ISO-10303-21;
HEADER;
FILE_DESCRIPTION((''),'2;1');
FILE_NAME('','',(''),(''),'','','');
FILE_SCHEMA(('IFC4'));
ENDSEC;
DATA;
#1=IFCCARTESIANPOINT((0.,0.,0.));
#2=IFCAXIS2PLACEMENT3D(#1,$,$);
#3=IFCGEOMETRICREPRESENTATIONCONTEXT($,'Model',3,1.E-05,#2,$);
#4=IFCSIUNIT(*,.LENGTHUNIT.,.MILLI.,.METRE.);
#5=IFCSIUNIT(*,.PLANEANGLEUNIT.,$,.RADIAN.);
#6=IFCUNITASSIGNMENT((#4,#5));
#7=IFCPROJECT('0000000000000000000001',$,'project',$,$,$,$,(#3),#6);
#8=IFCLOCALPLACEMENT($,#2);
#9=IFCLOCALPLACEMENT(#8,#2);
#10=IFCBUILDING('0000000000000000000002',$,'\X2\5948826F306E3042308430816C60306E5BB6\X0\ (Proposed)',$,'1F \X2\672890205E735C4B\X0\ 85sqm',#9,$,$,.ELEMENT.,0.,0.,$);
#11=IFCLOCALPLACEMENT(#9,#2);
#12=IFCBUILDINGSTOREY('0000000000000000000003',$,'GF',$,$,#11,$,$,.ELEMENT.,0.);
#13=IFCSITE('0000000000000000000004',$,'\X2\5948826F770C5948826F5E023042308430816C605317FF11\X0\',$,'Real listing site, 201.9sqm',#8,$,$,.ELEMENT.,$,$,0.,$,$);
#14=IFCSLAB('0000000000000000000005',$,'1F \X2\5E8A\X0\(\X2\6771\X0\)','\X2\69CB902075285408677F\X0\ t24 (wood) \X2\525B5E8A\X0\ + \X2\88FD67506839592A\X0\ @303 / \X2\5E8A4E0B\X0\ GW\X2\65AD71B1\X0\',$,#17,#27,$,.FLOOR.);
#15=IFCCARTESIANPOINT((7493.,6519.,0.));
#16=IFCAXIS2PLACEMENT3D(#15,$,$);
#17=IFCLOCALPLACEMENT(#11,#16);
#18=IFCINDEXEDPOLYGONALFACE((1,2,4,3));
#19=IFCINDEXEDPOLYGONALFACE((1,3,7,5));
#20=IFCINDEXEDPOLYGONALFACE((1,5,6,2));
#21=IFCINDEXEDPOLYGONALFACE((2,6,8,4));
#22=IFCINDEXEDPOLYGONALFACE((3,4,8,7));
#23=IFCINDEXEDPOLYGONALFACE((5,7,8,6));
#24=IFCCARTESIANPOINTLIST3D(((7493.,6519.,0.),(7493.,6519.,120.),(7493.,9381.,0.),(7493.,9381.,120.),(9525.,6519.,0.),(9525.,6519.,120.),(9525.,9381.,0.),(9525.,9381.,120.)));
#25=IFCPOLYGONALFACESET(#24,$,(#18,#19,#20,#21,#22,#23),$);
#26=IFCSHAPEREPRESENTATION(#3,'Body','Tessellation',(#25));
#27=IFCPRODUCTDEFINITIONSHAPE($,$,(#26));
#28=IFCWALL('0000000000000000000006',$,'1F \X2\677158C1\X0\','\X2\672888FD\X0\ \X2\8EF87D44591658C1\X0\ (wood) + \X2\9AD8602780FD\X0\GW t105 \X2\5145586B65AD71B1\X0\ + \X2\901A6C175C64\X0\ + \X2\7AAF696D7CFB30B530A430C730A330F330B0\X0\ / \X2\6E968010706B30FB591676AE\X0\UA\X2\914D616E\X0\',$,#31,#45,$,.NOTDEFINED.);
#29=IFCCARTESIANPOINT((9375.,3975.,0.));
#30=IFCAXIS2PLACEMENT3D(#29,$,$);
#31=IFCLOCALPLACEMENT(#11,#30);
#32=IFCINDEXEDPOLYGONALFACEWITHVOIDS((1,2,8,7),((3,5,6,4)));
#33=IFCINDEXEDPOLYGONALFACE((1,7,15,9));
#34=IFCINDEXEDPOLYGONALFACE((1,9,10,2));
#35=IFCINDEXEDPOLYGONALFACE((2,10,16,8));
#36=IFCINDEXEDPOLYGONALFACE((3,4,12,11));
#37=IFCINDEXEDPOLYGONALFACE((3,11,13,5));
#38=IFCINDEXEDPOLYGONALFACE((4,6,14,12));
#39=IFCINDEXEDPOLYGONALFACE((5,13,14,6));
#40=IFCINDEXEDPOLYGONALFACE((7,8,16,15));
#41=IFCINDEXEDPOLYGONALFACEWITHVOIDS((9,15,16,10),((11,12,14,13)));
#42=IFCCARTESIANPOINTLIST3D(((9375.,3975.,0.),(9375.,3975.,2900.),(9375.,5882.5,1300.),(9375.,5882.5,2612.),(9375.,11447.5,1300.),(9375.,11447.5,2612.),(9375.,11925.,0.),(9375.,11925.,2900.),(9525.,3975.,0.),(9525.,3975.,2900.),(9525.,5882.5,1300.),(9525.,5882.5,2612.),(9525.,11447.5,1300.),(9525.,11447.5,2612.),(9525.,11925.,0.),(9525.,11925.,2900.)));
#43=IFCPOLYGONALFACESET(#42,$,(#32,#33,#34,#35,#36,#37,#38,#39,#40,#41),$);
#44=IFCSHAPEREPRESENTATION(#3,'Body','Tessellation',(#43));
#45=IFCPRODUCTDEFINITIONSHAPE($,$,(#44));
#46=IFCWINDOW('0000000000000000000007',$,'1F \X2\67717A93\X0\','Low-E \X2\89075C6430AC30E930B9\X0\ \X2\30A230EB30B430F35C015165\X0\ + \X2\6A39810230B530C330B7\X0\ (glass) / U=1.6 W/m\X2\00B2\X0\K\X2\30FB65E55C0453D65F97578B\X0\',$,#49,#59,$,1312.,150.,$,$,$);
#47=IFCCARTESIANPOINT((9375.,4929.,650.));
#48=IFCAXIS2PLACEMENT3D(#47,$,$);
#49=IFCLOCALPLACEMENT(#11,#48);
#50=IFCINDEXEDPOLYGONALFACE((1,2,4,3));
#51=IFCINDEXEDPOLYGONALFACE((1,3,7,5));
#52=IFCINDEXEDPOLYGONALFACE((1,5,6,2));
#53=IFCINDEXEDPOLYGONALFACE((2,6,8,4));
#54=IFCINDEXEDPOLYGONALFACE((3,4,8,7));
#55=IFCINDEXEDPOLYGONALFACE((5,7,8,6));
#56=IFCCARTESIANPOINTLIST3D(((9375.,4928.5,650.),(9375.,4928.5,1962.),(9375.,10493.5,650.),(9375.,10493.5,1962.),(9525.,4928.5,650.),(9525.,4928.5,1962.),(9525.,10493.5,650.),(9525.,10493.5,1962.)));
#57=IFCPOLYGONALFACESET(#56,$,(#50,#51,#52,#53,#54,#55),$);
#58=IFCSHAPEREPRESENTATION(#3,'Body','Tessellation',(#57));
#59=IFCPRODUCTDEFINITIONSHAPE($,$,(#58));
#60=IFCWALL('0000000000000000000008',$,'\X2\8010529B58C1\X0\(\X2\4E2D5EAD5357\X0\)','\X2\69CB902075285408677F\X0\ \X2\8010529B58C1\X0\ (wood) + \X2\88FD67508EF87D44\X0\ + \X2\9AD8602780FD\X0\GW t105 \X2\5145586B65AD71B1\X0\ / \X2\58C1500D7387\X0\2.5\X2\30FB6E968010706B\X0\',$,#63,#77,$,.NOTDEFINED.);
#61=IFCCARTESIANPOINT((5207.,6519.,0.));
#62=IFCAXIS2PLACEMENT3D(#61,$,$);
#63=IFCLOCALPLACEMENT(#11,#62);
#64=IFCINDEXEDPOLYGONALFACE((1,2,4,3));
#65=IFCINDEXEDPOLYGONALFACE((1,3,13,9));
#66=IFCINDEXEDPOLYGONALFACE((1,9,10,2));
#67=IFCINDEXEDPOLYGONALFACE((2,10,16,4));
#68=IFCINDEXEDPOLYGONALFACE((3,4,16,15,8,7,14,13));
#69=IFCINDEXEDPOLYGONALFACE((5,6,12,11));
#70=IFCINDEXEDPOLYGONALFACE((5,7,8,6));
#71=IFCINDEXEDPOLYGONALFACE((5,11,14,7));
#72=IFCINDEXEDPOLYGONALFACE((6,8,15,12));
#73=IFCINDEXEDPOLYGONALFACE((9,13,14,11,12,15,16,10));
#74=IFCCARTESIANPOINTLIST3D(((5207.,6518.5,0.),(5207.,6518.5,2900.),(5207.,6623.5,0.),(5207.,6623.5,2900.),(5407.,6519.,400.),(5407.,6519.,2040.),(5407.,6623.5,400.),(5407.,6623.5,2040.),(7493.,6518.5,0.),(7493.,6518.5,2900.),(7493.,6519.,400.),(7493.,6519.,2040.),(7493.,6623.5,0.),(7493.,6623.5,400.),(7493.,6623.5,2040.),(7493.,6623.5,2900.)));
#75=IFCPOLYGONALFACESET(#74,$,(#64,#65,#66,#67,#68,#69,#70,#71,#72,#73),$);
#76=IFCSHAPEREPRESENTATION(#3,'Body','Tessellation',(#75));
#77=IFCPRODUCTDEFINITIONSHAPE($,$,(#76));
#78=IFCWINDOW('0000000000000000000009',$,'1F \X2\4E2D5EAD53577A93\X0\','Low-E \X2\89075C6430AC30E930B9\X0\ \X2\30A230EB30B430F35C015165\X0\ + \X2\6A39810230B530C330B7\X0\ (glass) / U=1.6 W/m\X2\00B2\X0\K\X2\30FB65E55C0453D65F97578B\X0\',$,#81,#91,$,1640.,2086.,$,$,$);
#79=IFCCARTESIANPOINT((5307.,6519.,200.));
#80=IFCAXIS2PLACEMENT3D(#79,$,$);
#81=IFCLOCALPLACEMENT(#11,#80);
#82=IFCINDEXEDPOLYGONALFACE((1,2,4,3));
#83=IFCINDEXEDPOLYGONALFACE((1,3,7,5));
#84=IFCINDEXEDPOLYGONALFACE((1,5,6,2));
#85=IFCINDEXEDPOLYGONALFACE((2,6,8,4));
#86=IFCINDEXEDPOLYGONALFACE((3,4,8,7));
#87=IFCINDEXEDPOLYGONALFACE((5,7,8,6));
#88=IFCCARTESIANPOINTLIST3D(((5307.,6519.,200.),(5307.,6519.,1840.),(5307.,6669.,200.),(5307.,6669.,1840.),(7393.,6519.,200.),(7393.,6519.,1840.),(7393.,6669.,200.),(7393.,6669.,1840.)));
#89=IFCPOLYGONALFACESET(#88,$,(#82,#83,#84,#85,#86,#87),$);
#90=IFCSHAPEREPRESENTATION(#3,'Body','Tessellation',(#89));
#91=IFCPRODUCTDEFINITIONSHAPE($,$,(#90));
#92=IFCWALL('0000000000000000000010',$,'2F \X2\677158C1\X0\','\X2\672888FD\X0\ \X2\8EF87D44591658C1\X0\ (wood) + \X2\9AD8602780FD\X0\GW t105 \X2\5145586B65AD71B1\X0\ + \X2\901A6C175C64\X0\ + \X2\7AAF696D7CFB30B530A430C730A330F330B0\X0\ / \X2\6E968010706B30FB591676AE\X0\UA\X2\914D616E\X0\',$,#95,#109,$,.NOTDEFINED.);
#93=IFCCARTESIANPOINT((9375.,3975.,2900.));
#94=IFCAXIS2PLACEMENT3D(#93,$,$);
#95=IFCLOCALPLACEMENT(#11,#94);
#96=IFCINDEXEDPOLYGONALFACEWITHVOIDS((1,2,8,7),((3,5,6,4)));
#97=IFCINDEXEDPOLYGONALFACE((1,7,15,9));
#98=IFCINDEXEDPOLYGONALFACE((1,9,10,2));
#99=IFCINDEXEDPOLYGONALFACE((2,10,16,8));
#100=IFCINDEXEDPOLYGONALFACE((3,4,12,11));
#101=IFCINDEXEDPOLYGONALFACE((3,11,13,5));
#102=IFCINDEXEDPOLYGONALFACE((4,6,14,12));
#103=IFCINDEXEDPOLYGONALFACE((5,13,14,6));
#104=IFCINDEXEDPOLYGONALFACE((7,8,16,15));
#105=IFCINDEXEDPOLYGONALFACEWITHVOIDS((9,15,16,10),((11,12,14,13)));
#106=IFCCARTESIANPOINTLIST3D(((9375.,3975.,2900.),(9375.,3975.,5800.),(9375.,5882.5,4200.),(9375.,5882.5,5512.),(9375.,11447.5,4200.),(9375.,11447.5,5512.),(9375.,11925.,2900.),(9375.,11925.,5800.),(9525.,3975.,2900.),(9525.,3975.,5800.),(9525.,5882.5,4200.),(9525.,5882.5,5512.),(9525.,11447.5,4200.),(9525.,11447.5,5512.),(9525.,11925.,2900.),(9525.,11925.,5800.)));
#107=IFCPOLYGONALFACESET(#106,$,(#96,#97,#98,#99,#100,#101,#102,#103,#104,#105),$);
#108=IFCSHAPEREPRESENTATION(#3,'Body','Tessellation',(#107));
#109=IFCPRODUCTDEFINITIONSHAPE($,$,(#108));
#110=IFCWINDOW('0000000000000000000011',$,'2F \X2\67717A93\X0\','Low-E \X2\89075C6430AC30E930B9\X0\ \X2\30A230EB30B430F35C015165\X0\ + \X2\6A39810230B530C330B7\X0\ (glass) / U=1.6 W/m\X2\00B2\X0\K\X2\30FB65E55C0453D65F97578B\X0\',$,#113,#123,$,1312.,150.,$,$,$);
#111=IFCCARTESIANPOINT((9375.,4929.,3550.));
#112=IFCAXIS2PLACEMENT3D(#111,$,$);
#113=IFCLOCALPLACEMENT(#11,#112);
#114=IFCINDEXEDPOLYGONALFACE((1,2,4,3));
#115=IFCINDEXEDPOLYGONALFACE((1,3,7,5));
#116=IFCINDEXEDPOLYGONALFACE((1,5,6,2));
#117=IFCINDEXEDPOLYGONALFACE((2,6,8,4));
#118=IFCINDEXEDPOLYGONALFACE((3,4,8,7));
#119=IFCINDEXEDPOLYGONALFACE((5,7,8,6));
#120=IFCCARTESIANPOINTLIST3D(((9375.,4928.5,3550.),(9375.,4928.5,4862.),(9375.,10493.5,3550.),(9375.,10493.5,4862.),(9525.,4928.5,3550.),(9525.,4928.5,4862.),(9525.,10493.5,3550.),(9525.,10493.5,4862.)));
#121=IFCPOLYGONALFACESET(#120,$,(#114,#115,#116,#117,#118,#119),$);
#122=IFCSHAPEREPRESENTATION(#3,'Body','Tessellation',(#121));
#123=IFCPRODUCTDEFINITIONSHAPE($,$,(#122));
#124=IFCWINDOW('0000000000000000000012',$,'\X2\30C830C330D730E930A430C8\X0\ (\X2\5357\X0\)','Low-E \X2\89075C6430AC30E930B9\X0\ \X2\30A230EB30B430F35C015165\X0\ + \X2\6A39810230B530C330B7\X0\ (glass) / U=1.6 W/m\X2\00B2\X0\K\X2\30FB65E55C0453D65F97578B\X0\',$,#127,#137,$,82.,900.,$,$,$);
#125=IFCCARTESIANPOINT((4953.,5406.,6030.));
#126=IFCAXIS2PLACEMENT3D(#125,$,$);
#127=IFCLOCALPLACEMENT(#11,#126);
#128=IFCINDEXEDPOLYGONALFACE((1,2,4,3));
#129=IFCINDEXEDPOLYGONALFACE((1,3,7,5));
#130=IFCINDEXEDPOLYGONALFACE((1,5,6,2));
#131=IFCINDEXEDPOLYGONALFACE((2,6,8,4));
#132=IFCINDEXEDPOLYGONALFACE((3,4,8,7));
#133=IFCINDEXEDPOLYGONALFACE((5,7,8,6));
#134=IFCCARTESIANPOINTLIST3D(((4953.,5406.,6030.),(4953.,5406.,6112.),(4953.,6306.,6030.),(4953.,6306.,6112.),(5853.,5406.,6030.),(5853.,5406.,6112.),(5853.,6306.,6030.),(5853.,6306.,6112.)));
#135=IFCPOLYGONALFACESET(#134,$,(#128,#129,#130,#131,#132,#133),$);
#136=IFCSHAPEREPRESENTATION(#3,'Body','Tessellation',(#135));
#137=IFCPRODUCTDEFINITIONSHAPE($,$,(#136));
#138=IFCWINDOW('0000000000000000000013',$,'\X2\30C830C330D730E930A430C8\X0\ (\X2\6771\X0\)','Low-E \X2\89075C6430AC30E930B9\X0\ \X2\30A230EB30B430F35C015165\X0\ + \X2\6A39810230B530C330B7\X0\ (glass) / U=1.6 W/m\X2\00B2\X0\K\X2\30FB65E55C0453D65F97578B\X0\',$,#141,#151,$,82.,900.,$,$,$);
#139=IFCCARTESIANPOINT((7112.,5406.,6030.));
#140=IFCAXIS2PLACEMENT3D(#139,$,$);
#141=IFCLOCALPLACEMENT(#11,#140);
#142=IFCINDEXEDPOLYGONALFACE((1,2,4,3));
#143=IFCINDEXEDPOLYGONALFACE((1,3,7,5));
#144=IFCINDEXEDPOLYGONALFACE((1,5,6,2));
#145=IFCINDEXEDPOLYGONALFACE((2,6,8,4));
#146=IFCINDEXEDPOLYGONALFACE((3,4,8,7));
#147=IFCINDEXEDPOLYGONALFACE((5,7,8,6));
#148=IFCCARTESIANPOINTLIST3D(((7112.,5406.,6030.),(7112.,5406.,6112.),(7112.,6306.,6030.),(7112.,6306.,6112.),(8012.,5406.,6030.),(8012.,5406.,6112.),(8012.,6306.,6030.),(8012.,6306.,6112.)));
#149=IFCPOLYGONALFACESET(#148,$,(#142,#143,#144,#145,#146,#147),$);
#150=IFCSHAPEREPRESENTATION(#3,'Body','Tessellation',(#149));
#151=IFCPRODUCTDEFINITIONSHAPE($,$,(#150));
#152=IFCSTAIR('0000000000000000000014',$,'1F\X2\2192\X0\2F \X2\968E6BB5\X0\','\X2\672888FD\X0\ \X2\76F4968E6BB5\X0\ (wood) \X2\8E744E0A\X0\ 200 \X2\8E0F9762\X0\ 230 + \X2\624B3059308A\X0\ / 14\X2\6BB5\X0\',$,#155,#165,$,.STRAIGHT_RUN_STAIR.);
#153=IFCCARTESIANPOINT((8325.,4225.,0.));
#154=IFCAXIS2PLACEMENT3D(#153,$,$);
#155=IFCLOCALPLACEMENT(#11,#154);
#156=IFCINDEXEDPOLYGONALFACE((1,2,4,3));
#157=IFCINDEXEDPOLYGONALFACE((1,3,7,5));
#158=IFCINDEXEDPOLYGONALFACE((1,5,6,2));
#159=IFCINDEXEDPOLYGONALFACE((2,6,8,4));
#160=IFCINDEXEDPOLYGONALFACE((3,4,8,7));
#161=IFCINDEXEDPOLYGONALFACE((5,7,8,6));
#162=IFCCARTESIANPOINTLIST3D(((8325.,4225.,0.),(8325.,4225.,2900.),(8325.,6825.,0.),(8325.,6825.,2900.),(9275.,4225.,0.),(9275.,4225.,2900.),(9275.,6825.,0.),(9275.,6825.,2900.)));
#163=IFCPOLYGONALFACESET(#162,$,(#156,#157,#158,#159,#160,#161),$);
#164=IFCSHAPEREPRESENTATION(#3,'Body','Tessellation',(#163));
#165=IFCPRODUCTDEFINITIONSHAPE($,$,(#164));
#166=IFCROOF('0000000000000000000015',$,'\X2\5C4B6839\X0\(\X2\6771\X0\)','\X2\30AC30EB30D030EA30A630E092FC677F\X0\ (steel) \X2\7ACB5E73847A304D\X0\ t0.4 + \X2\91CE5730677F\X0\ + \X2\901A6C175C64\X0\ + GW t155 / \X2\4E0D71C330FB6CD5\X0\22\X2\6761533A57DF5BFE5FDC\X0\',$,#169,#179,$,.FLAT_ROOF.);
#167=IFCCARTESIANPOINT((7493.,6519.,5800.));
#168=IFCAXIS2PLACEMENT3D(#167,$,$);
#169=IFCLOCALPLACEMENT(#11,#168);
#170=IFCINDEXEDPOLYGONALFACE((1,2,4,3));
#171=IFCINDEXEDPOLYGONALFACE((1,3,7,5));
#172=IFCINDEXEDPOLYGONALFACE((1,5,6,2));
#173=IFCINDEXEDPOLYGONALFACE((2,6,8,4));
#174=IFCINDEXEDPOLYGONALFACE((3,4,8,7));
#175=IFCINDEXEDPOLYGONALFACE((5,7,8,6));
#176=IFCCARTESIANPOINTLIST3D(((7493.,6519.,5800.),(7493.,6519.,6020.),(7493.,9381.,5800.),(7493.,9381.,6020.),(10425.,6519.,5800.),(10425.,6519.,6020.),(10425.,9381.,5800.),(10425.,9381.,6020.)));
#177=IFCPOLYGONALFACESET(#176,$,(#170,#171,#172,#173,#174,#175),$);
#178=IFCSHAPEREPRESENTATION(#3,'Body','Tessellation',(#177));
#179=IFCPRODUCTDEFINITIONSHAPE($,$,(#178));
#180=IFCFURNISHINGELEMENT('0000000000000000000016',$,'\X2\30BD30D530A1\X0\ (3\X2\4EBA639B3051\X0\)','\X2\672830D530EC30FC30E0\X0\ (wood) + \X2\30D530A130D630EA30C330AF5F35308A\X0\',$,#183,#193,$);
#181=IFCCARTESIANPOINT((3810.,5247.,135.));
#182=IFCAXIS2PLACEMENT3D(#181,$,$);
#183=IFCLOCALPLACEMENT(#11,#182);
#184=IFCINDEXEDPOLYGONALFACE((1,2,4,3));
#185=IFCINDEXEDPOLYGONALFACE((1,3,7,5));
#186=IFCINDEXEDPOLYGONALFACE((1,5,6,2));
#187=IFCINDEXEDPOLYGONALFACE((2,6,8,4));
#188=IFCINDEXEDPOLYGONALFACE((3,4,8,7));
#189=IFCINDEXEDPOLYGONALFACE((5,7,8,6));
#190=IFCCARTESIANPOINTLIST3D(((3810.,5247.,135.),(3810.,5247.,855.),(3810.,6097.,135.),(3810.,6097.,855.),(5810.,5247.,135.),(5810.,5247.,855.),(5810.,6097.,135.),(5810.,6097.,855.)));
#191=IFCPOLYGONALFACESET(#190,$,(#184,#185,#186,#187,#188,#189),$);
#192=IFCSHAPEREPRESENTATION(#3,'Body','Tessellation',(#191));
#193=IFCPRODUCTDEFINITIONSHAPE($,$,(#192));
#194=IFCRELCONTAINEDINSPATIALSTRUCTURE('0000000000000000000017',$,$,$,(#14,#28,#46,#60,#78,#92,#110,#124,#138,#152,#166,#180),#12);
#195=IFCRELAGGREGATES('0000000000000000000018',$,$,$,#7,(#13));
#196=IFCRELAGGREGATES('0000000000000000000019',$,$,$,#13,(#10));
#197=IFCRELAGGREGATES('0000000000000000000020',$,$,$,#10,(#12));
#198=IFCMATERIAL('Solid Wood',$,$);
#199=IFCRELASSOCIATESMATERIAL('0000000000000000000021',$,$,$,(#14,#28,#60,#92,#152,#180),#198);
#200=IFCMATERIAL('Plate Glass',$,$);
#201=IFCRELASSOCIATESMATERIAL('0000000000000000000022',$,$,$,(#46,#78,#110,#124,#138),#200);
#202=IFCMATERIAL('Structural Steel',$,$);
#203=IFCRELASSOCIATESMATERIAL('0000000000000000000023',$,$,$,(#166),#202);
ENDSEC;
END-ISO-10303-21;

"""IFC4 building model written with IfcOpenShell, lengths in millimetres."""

from ifc_helpers import new_model, si_unit, frame, frame_2d, origin, place, context, project, spatial, rectangle, extrude, material, element, fill, save


model = new_model("IFC4")

# Units and contexts
model_context = context("Model", 3, precision=1e-05, world=origin())
ifc_project = project(units=[si_unit("LENGTHUNIT", "METRE", prefix="MILLI"), si_unit("PLANEANGLEUNIT", "RADIAN")], contexts=[model_context])

# Site, building, storey
site_placement = place(None, origin())
site = spatial("IfcSite", under=ifc_project, at=site_placement, Name="奈良県奈良市あやめ池北１", ObjectType="Real listing site, 201.9sqm", CompositionType="ELEMENT", RefElevation=0.0)
building_placement = place(site_placement, origin())
building = spatial("IfcBuilding", under=site, at=building_placement, Name="奈良のあやめ池の家 (Proposed)", ObjectType="1F 木造平屋 85sqm", CompositionType="ELEMENT", ElevationOfRefHeight=0.0, ElevationOfTerrain=0.0)
storey_placement = place(building_placement, origin())
storey = spatial("IfcBuildingStorey", under=building, at=storey_placement, Name="GF", CompositionType="ELEMENT", Elevation=0.0)

# Slab
ifc_material_1 = material(Name="Solid Wood")
slab_placement = place(storey_placement, frame((7493.0, 6519.0, 0.0)))
element("IfcSlab", 1, at=slab_placement, inside=storey, material=ifc_material_1, Name="1F 床(東)", Description="構造用合板 t24 (wood) 剛床 + 製材根太 @303 / 床下 GW断熱", PredefinedType="FLOOR", context=model_context, shape_type="SweptSolid", body=[
    extrude(rectangle(XDim=2032.0, YDim=2862.0, at=frame_2d((1016.0, 1431.0))), frame((7493.0, 6519.0, 0.0)), (0.0, 0.0, 1.0), 120.0),
])

# Walls, openings, windows
wall_1_placement = place(storey_placement, frame((9375.0, 3975.0, 0.0)))
wall_1 = element("IfcWall", 2, at=wall_1_placement, inside=storey, material=ifc_material_1, Name="1F 東壁", Description="木製 軸組外壁 (wood) + 高性能GW t105 充填断熱 + 通気層 + 窯業系サイディング / 準耐火・外皮UA配慮", PredefinedType="NOTDEFINED", context=model_context, shape_type="SweptSolid", body=[
    extrude(rectangle(XDim=150.0, YDim=7950.0, at=frame_2d((75.0, 3975.0))), frame((9375.0, 3975.0, 0.0)), (0.0, 0.0, 1.0), 2900.0),
])
opening_1_placement = place(storey_placement, frame((9375.0, 4929.0, 650.0)))
opening_1 = element("IfcOpeningElement", 3, at=opening_1_placement, cuts=wall_1, PredefinedType="NOTDEFINED", context=model_context, shape_type="SweptSolid", body=[
    extrude(rectangle(XDim=150.0, YDim=5565.0, at=frame_2d((75.0, 2782.0))), frame((9375.0, 4929.0, 650.0)), (0.0, 0.0, 1.0), 1312.0),
])
ifc_material_2 = material(Name="Plate Glass")
window_1_placement = place(storey_placement, frame((9375.0, 4929.0, 650.0)))
window_1 = element("IfcWindow", 4, at=window_1_placement, inside=storey, material=ifc_material_2, Name="1F 東窓", Description="Low-E 複層ガラス アルゴン封入 + 樹脂サッシ (glass) / U=1.6 W/m²K・日射取得型", OverallHeight=1312.0, OverallWidth=150.0, context=model_context, shape_type="SweptSolid", body=[
    extrude(rectangle(XDim=150.0, YDim=5565.0, at=frame_2d((75.0, 2782.0))), frame((9375.0, 4929.0, 650.0)), (0.0, 0.0, 1.0), 1312.0),
])
fill(opening_1, window_1)
wall_2_placement = place(storey_placement, frame((5207.0, 6519.0, 0.0)))
wall_2 = element("IfcWall", 5, at=wall_2_placement, inside=storey, material=ifc_material_1, Name="耐力壁(中庭南)", Description="構造用合板 耐力壁 (wood) + 製材軸組 + 高性能GW t105 充填断熱 / 壁倍率2.5・準耐火", PredefinedType="NOTDEFINED", context=model_context, shape_type="SweptSolid", body=[
    extrude(rectangle(XDim=2286.0, YDim=105.0, at=frame_2d((1143.0, 52.0))), frame((5207.0, 6519.0, 0.0)), (0.0, 0.0, 1.0), 2900.0),
])
opening_2_placement = place(storey_placement, frame((5307.0, 6519.0, 200.0)))
opening_2 = element("IfcOpeningElement", 6, at=opening_2_placement, cuts=wall_2, PredefinedType="NOTDEFINED", context=model_context, shape_type="SweptSolid", body=[
    extrude(rectangle(XDim=2086.0, YDim=150.0, at=frame_2d((1043.0, 75.0))), frame((5307.0, 6519.0, 200.0)), (0.0, 0.0, 1.0), 1640.0),
])
window_2_placement = place(storey_placement, frame((5307.0, 6519.0, 200.0)))
window_2 = element("IfcWindow", 7, at=window_2_placement, inside=storey, material=ifc_material_2, Name="1F 中庭南窓", Description="Low-E 複層ガラス アルゴン封入 + 樹脂サッシ (glass) / U=1.6 W/m²K・日射取得型", OverallHeight=1640.0, OverallWidth=2086.0, context=model_context, shape_type="SweptSolid", body=[
    extrude(rectangle(XDim=2086.0, YDim=150.0, at=frame_2d((1043.0, 75.0))), frame((5307.0, 6519.0, 200.0)), (0.0, 0.0, 1.0), 1640.0),
])
fill(opening_2, window_2)

# Wall, opening, window
wall_3_placement = place(storey_placement, frame((9375.0, 3975.0, 2900.0)))
wall_3 = element("IfcWall", 8, at=wall_3_placement, inside=storey, material=ifc_material_1, Name="2F 東壁", Description="木製 軸組外壁 (wood) + 高性能GW t105 充填断熱 + 通気層 + 窯業系サイディング / 準耐火・外皮UA配慮", PredefinedType="NOTDEFINED", context=model_context, shape_type="SweptSolid", body=[
    extrude(rectangle(XDim=150.0, YDim=7950.0, at=frame_2d((75.0, 3975.0))), frame((9375.0, 3975.0, 2900.0)), (0.0, 0.0, 1.0), 2900.0),
])
opening_3_placement = place(storey_placement, frame((9375.0, 4929.0, 3550.0)))
opening_3 = element("IfcOpeningElement", 9, at=opening_3_placement, cuts=wall_3, PredefinedType="NOTDEFINED", context=model_context, shape_type="SweptSolid", body=[
    extrude(rectangle(XDim=150.0, YDim=5565.0, at=frame_2d((75.0, 2782.0))), frame((9375.0, 4929.0, 3550.0)), (0.0, 0.0, 1.0), 1312.0),
])
window_3_placement = place(storey_placement, frame((9375.0, 4929.0, 3550.0)))
window_3 = element("IfcWindow", 10, at=window_3_placement, inside=storey, material=ifc_material_2, Name="2F 東窓", Description="Low-E 複層ガラス アルゴン封入 + 樹脂サッシ (glass) / U=1.6 W/m²K・日射取得型", OverallHeight=1312.0, OverallWidth=150.0, context=model_context, shape_type="SweptSolid", body=[
    extrude(rectangle(XDim=150.0, YDim=5565.0, at=frame_2d((75.0, 2782.0))), frame((9375.0, 4929.0, 3550.0)), (0.0, 0.0, 1.0), 1312.0),
])
fill(opening_3, window_3)

# Windows
window_4_placement = place(storey_placement, frame((4953.0, 5406.0, 6030.0)))
element("IfcWindow", 11, at=window_4_placement, inside=storey, material=ifc_material_2, Name="トップライト (南)", Description="Low-E 複層ガラス アルゴン封入 + 樹脂サッシ (glass) / U=1.6 W/m²K・日射取得型", OverallHeight=82.0, OverallWidth=900.0, context=model_context, shape_type="SweptSolid", body=[
    extrude(rectangle(XDim=900.0, YDim=900.0, at=frame_2d((450.0, 450.0))), frame((4953.0, 5406.0, 6030.0)), (0.0, 0.0, 1.0), 82.0),
])
window_5_placement = place(storey_placement, frame((7112.0, 5406.0, 6030.0)))
element("IfcWindow", 12, at=window_5_placement, inside=storey, material=ifc_material_2, Name="トップライト (東)", Description="Low-E 複層ガラス アルゴン封入 + 樹脂サッシ (glass) / U=1.6 W/m²K・日射取得型", OverallHeight=82.0, OverallWidth=900.0, context=model_context, shape_type="SweptSolid", body=[
    extrude(rectangle(XDim=900.0, YDim=900.0, at=frame_2d((450.0, 450.0))), frame((7112.0, 5406.0, 6030.0)), (0.0, 0.0, 1.0), 82.0),
])

# Stair
stair_placement = place(storey_placement, frame((8325.0, 4225.0, 0.0)))
element("IfcStair", 13, at=stair_placement, inside=storey, material=ifc_material_1, Name="1F→2F 階段", Description="木製 直階段 (wood) 蹴上 200 踏面 230 + 手すり / 14段", PredefinedType="STRAIGHT_RUN_STAIR", context=model_context, shape_type="SweptSolid", body=[
    extrude(rectangle(XDim=950.0, YDim=2600.0, at=frame_2d((475.0, 1300.0))), frame((8325.0, 4225.0, 0.0)), (0.0, 0.0, 1.0), 2900.0),
])

# Roof
ifc_material_3 = material(Name="Structural Steel")
roof_placement = place(storey_placement, frame((7493.0, 6519.0, 5800.0)))
element("IfcRoof", 14, at=roof_placement, inside=storey, material=ifc_material_3, Name="屋根(東)", Description="ガルバリウム鋼板 (steel) 立平葺き t0.4 + 野地板 + 通気層 + GW t155 / 不燃・法22条区域対応", PredefinedType="FLAT_ROOF", context=model_context, shape_type="SweptSolid", body=[
    extrude(rectangle(XDim=2932.0, YDim=2862.0, at=frame_2d((1466.0, 1431.0))), frame((7493.0, 6519.0, 5800.0)), (0.0, 0.0, 1.0), 220.0),
])

# Furnishing element
furnishing_1_placement = place(storey_placement, frame((3810.0, 5247.0, 135.0)))
element("IfcFurnishingElement", 15, at=furnishing_1_placement, inside=storey, material=ifc_material_1, Name="ソファ (3人掛け)", Description="木フレーム (wood) + ファブリック張り", context=model_context, shape_type="SweptSolid", body=[
    extrude(rectangle(XDim=2000.0, YDim=850.0, at=frame_2d((1000.0, 425.0))), frame((3810.0, 5247.0, 135.0)), (0.0, 0.0, 1.0), 720.0),
])

save(model, "model.ifc")
